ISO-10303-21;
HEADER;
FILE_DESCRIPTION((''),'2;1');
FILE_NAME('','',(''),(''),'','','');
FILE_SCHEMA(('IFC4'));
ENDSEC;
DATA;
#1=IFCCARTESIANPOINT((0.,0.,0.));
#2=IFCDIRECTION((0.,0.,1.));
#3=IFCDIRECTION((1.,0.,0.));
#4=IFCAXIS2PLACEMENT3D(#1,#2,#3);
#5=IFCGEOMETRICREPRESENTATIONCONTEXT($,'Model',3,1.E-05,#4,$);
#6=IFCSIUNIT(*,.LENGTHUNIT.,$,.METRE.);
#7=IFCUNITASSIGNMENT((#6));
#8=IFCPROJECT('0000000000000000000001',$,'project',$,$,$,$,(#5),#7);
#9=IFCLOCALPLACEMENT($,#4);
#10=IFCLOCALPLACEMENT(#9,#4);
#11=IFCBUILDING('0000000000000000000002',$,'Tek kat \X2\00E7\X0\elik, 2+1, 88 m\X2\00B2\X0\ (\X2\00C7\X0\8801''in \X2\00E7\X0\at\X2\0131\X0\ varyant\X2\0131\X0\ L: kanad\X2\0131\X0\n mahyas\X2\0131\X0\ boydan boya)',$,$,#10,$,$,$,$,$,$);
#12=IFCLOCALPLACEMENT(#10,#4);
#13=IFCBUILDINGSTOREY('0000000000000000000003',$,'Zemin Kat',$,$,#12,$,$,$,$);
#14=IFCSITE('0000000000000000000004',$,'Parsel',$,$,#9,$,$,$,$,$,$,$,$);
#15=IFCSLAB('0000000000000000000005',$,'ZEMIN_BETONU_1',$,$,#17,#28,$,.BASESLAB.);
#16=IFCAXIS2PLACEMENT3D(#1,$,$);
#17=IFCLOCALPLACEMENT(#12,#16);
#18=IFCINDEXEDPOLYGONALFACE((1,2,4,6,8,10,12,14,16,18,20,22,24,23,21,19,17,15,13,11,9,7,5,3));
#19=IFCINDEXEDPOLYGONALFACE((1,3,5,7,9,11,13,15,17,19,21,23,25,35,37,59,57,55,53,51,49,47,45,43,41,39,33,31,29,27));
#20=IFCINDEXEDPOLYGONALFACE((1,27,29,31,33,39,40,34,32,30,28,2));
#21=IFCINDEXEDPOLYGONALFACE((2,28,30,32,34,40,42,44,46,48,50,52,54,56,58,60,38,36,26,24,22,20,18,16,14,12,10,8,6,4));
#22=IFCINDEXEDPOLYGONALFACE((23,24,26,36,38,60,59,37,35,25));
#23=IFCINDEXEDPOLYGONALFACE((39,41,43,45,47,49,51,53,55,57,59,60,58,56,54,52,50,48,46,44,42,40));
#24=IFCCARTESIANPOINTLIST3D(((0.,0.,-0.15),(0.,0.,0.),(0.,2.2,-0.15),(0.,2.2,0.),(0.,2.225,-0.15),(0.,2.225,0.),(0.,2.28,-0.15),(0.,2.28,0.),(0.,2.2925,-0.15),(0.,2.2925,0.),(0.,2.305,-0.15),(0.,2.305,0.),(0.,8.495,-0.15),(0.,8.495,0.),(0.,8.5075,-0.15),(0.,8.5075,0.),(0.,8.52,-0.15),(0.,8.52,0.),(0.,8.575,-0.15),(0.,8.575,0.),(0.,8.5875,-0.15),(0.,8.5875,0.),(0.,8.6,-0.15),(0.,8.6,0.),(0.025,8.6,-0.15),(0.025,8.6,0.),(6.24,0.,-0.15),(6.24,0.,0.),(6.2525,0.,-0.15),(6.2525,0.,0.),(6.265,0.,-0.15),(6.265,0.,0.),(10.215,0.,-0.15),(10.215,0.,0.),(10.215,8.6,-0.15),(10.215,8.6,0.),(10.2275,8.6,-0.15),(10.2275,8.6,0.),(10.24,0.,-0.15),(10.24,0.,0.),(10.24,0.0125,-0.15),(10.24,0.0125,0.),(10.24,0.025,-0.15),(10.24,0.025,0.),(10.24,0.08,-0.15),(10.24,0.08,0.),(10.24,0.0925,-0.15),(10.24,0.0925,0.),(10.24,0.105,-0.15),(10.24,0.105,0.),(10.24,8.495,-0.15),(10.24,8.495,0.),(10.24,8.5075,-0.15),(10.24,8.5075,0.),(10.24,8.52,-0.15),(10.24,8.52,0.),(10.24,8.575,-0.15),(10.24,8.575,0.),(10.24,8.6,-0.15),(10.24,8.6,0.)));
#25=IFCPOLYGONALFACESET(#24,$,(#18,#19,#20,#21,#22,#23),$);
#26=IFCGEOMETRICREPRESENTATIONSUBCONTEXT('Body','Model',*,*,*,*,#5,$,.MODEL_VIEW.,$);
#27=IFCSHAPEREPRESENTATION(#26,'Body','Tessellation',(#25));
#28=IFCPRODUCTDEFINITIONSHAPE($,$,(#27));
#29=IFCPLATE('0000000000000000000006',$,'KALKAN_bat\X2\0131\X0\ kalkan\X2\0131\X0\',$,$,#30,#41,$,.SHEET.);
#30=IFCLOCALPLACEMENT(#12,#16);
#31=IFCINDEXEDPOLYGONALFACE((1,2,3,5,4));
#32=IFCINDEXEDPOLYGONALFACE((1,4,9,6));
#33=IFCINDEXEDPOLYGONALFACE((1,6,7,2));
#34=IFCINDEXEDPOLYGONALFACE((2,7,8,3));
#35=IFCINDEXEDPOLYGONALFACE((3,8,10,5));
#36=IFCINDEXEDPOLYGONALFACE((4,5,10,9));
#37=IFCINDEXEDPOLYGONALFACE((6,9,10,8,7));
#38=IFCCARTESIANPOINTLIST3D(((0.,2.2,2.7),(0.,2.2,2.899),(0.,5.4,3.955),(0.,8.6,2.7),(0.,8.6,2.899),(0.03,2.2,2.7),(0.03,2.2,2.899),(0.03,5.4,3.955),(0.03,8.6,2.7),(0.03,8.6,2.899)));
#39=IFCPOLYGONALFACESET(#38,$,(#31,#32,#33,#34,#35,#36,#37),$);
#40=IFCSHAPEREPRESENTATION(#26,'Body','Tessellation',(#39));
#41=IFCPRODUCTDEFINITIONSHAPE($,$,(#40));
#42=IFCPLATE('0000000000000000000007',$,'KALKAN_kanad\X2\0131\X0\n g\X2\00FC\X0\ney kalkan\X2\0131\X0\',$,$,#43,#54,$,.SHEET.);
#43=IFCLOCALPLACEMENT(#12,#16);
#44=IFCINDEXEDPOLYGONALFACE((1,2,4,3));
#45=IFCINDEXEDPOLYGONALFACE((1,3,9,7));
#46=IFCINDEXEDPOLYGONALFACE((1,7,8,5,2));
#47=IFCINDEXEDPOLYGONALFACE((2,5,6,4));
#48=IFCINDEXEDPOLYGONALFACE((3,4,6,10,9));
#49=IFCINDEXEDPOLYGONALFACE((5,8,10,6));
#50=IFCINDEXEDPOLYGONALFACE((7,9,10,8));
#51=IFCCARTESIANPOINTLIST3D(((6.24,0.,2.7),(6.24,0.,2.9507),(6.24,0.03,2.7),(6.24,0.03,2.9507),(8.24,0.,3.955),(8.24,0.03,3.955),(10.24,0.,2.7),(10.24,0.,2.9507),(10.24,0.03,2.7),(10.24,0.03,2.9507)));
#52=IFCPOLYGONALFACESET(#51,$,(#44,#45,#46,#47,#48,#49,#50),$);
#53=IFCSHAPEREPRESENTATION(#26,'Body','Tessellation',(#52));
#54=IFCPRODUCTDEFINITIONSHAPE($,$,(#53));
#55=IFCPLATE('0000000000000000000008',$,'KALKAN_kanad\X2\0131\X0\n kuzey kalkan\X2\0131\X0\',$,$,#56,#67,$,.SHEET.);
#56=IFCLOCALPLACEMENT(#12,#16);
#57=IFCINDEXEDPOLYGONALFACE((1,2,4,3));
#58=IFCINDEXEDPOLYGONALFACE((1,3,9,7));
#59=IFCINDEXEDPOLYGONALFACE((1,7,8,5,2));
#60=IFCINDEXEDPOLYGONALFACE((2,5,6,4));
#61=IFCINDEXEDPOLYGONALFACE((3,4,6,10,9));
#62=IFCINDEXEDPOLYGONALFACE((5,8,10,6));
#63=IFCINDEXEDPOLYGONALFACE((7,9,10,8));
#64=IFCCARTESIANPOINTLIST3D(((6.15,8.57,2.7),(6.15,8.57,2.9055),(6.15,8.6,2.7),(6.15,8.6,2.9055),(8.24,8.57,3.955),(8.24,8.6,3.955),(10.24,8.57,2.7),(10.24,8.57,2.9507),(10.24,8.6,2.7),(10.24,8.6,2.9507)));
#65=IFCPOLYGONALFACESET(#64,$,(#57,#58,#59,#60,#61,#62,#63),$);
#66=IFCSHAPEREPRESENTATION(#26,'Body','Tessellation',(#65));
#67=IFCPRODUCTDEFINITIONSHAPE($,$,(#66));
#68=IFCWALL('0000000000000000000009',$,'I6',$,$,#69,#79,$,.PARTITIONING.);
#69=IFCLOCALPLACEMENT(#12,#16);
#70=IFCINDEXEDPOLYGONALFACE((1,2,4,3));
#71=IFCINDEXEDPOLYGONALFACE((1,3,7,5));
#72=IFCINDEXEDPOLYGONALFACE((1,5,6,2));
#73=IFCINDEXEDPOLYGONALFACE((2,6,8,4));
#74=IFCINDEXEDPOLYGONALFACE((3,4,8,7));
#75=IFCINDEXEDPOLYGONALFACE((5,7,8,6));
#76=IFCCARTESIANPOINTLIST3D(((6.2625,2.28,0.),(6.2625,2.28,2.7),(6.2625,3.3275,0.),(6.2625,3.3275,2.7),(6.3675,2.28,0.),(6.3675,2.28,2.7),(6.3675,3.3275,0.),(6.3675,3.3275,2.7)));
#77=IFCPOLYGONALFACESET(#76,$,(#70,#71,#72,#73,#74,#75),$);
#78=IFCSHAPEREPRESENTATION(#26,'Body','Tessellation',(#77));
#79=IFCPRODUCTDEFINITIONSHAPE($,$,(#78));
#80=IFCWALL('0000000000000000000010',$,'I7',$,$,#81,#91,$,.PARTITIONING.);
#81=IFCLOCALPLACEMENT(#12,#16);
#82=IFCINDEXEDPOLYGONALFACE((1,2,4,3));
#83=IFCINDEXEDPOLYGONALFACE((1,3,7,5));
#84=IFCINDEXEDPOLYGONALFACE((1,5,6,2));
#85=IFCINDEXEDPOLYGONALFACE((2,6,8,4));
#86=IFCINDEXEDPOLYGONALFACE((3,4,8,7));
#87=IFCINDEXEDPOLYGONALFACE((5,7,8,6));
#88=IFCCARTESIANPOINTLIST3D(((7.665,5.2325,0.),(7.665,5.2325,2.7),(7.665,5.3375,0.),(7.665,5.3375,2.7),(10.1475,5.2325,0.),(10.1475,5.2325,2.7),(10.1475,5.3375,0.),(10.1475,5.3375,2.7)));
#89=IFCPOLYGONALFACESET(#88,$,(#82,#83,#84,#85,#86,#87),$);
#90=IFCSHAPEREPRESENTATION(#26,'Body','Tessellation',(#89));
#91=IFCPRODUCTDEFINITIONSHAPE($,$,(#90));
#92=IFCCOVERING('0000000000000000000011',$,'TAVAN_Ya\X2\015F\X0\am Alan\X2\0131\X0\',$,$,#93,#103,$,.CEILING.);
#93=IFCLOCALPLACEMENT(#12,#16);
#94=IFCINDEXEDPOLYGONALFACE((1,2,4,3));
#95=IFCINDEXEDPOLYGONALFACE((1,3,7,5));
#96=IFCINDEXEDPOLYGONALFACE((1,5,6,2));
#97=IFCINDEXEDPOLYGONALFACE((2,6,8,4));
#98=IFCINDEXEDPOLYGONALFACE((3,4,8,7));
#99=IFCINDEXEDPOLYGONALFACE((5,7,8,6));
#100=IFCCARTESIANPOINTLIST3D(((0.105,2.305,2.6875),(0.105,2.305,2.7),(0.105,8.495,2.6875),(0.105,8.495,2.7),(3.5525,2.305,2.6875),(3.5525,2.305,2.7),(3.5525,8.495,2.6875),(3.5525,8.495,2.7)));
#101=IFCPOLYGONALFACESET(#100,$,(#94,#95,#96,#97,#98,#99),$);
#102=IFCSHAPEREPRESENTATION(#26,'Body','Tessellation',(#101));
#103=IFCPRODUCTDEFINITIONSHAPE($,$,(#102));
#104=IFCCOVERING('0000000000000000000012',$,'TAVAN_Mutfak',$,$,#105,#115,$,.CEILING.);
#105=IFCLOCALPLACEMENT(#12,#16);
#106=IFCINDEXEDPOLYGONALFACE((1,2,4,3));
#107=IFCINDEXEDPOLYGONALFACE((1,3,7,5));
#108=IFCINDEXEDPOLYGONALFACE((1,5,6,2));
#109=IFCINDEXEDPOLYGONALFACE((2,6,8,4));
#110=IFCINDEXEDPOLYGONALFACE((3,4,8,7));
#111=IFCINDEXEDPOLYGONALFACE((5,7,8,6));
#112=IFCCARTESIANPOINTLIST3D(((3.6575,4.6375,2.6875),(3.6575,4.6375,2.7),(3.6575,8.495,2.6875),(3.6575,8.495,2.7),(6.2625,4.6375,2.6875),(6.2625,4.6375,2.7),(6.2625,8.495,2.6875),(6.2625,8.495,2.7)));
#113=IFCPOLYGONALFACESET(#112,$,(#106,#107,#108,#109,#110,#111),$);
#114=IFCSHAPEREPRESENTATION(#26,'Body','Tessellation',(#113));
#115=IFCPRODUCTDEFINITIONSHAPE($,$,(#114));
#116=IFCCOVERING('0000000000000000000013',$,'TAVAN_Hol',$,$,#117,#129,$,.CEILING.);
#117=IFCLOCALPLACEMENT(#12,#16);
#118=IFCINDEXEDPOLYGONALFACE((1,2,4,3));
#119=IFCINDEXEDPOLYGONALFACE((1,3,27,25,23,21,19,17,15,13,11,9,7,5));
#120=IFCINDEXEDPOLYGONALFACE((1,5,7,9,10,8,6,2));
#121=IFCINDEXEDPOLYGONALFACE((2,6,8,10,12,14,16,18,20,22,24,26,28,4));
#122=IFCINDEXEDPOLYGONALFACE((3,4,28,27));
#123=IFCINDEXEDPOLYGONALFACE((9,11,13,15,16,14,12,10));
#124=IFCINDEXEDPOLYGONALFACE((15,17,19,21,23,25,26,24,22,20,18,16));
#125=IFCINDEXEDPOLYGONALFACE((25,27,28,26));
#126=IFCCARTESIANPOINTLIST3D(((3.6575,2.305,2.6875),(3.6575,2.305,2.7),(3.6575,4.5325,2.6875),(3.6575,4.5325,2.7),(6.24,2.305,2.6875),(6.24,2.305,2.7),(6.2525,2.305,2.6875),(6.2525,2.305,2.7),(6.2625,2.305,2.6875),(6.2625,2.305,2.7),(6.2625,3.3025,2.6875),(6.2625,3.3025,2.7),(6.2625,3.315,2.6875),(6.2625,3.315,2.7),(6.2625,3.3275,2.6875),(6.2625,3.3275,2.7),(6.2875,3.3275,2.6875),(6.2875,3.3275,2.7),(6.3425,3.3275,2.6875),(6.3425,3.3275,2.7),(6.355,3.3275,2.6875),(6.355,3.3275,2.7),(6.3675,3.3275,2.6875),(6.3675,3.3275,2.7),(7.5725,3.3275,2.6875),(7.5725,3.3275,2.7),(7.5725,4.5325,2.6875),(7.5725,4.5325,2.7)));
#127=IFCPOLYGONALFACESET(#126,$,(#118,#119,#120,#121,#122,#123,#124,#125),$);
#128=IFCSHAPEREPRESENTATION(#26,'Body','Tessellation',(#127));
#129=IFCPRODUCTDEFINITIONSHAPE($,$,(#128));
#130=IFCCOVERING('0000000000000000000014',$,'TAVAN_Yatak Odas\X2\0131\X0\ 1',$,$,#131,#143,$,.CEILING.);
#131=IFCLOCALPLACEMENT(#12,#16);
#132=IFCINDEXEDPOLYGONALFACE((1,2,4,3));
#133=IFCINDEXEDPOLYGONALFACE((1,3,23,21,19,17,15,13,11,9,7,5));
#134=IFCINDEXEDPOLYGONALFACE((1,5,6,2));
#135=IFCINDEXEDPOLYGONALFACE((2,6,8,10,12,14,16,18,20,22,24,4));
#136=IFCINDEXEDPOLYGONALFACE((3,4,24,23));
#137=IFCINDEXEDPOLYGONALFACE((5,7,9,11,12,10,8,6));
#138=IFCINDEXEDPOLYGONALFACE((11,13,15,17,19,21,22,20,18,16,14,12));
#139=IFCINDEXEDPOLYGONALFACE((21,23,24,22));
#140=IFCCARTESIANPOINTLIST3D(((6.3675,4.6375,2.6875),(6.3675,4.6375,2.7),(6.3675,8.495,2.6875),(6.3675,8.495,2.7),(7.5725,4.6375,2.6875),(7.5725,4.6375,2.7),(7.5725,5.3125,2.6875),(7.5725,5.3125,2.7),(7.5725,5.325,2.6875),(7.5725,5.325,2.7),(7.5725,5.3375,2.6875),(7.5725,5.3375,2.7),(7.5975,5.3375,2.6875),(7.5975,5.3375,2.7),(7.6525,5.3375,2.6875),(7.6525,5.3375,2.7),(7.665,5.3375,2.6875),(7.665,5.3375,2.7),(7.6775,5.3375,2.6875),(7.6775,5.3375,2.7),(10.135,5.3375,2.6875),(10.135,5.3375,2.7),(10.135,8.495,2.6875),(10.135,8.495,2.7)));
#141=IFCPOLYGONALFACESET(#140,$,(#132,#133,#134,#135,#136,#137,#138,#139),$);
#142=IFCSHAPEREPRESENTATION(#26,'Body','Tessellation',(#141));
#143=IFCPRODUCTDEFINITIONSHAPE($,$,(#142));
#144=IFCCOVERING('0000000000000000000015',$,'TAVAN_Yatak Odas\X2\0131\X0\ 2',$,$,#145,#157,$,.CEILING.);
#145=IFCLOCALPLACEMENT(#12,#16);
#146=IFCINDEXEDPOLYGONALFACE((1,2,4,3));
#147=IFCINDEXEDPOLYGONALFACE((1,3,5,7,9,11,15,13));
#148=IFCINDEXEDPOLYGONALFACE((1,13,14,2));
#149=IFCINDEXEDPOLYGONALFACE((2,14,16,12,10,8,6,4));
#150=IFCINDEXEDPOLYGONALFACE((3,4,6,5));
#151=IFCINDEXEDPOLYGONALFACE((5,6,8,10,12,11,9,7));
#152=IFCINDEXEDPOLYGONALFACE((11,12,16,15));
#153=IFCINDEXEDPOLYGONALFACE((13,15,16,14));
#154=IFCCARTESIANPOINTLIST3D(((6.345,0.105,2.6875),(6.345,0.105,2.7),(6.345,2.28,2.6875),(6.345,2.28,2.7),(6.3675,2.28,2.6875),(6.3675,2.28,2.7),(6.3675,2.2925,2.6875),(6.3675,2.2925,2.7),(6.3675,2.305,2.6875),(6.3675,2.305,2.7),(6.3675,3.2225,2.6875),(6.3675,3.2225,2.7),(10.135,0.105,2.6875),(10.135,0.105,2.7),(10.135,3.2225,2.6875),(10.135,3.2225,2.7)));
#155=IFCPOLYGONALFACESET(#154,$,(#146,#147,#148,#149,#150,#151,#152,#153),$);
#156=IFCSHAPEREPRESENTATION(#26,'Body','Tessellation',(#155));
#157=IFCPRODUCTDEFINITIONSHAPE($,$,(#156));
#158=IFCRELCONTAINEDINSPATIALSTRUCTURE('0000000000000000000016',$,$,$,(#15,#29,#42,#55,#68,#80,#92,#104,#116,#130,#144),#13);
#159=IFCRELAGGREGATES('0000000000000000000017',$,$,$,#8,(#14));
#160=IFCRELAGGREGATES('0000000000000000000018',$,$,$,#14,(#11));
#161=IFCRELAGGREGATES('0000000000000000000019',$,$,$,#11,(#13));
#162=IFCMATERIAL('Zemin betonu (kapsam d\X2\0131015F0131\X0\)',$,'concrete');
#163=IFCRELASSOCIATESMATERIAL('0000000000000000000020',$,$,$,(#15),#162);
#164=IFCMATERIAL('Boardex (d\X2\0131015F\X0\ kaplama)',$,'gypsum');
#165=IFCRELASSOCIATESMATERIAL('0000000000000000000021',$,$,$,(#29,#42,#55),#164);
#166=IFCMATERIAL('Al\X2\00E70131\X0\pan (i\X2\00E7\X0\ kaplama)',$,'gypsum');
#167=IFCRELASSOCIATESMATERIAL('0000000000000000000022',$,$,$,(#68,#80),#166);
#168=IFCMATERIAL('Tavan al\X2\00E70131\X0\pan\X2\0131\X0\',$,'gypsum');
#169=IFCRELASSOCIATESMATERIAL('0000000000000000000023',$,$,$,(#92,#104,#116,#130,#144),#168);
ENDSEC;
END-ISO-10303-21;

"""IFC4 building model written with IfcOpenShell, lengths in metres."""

from ifc_helpers import new_model, si_unit, frame, origin_with_axes, place, context, subcontext, project, spatial, line, indexed_curve, outline, extrude, material, element, save


model = new_model("IFC4")

# Units and contexts
model_context = context("Model", 3, precision=1e-05, world=origin_with_axes())
body_context = subcontext(model_context, "Body", "Model", "MODEL_VIEW")
ifc_project = project(units=[si_unit("LENGTHUNIT", "METRE")], contexts=[model_context])

# Site, building, storey
site_placement = place(None, origin_with_axes())
site = spatial("IfcSite", under=ifc_project, at=site_placement, Name="Parsel")
building_placement = place(site_placement, origin_with_axes())
building = spatial("IfcBuilding", under=site, at=building_placement, Name="Tek kat çelik, 2+1, 88 m² (Ç8801'in çatı varyantı L: kanadın mahyası boydan boya)")
storey_placement = place(building_placement, origin_with_axes())
storey = spatial("IfcBuildingStorey", under=building, at=storey_placement, Name="Zemin Kat")

# Slab
ifc_material_1 = material(Name="Zemin betonu (kapsam dışı)", Category="concrete")
slab_placement = place(storey_placement, origin_with_axes())
element("IfcSlab", 1, at=slab_placement, inside=storey, material=ifc_material_1, Name="ZEMIN_BETONU_1", PredefinedType="BASESLAB", context=body_context, shape_type="SweptSolid", body=[
    extrude(outline(indexed_curve([(6.24, 0.0), (6.2525, 0.0), (6.265, 0.0), (10.215, 0.0), (10.24, 0.0), (10.24, 0.0125), (10.24, 0.025), (10.24, 0.08), (10.24, 0.0925), (10.24, 0.105), (10.24, 8.495), (10.24, 8.5075), (10.24, 8.52), (10.24, 8.575), (10.24, 8.6), (10.2275, 8.6), (10.215, 8.6), (0.025, 8.6), (0.0, 8.6), (0.0, 8.5875), (0.0, 8.575), (0.0, 8.52), (0.0, 8.5075), (0.0, 8.495), (0.0, 2.305), (0.0, 2.2925), (0.0, 2.28), (0.0, 2.225), (0.0, 2.2), (0.0, 0.0)], segments=[line(1, 2, 3, 4, 5, 6, 7, 8, 9, 10, 11, 12, 13, 14, 15, 16, 17, 18, 19, 20, 21, 22, 23, 24, 25, 26, 27, 28, 29, 30, 1)])), frame((0.0, 0.0, -0.15), z_axis=(0.0, 0.0, 1.0), x_axis=(1.0, 0.0, 0.0)), (0.0, 0.0, 1.0), 0.15),
])

# Plates
ifc_material_2 = material(Name="Boardex (dış kaplama)", Category="gypsum")
plate_1_placement = place(storey_placement, origin_with_axes())
element("IfcPlate", 2, at=plate_1_placement, inside=storey, material=ifc_material_2, Name="KALKAN_batı kalkanı", PredefinedType="SHEET", context=body_context, shape_type="SweptSolid", body=[
    extrude(outline(indexed_curve([(2.2, 2.899), (5.4, 3.955), (8.6, 2.899), (8.6, 2.7), (2.2, 2.7)], segments=[line(1, 2, 3, 4, 5, 1)])), frame((0.0, 0.0, 0.0), z_axis=(1.0, 0.0, 0.0), x_axis=(0.0, 1.0, 0.0)), (0.0, 0.0, 1.0), 0.03),
])
plate_2_placement = place(storey_placement, origin_with_axes())
element("IfcPlate", 3, at=plate_2_placement, inside=storey, material=ifc_material_2, Name="KALKAN_kanadın güney kalkanı", PredefinedType="SHEET", context=body_context, shape_type="SweptSolid", body=[
    extrude(outline(indexed_curve([(6.24, 2.9507), (8.24, 3.955), (10.24, 2.9507), (10.24, 2.7), (6.24, 2.7)], segments=[line(1, 2, 3, 4, 5, 1)])), frame((0.0, 0.03, 0.0), z_axis=(0.0, -1.0, 0.0), x_axis=(1.0, 0.0, 0.0)), (0.0, 0.0, 1.0), 0.03),
])
plate_3_placement = place(storey_placement, origin_with_axes())
element("IfcPlate", 4, at=plate_3_placement, inside=storey, material=ifc_material_2, Name="KALKAN_kanadın kuzey kalkanı", PredefinedType="SHEET", context=body_context, shape_type="SweptSolid", body=[
    extrude(outline(indexed_curve([(6.15, 2.9055), (8.24, 3.955), (10.24, 2.9507), (10.24, 2.7), (6.15, 2.7)], segments=[line(1, 2, 3, 4, 5, 1)])), frame((0.0, 8.6, 0.0), z_axis=(0.0, -1.0, 0.0), x_axis=(1.0, 0.0, 0.0)), (0.0, 0.0, 1.0), 0.03),
])

# Walls
ifc_material_3 = material(Name="Alçıpan (iç kaplama)", Category="gypsum")
wall_1_placement = place(storey_placement, origin_with_axes())
element("IfcWall", 5, at=wall_1_placement, inside=storey, material=ifc_material_3, Name="I6", PredefinedType="PARTITIONING", context=body_context, shape_type="SweptSolid", body=[
    extrude(outline(indexed_curve([(0.0, 0.0), (0.105, 0.0), (0.105, 1.0475), (0.0, 1.0475)], segments=[line(1, 2, 3, 4, 1)])), frame((6.2625, 2.28, 0.0), z_axis=(0.0, 0.0, 1.0), x_axis=(1.0, 0.0, 0.0)), (0.0, 0.0, 1.0), 2.7),
])
wall_2_placement = place(storey_placement, origin_with_axes())
element("IfcWall", 6, at=wall_2_placement, inside=storey, material=ifc_material_3, Name="I7", PredefinedType="PARTITIONING", context=body_context, shape_type="SweptSolid", body=[
    extrude(outline(indexed_curve([(0.0, 0.0), (2.4825, 0.0), (2.4825, 0.105), (0.0, 0.105)], segments=[line(1, 2, 3, 4, 1)])), frame((7.665, 5.2325, 0.0), z_axis=(0.0, 0.0, 1.0), x_axis=(1.0, 0.0, 0.0)), (0.0, 0.0, 1.0), 2.7),
])

# Coverings
ifc_material_4 = material(Name="Tavan alçıpanı", Category="gypsum")
covering_1_placement = place(storey_placement, origin_with_axes())
element("IfcCovering", 7, at=covering_1_placement, inside=storey, material=ifc_material_4, Name="TAVAN_Yaşam Alanı", PredefinedType="CEILING", context=body_context, shape_type="SweptSolid", body=[
    extrude(outline(indexed_curve([(0.105, 8.495), (3.5525, 8.495), (3.5525, 2.305), (0.105, 2.305)], segments=[line(1, 2, 3, 4, 1)])), frame((0.0, 0.0, 2.6875), z_axis=(0.0, 0.0, 1.0), x_axis=(1.0, 0.0, 0.0)), (0.0, 0.0, 1.0), 0.0125),
])
covering_2_placement = place(storey_placement, origin_with_axes())
element("IfcCovering", 8, at=covering_2_placement, inside=storey, material=ifc_material_4, Name="TAVAN_Mutfak", PredefinedType="CEILING", context=body_context, shape_type="SweptSolid", body=[
    extrude(outline(indexed_curve([(3.6575, 8.495), (6.2625, 8.495), (6.2625, 4.6375), (3.6575, 4.6375)], segments=[line(1, 2, 3, 4, 1)])), frame((0.0, 0.0, 2.6875), z_axis=(0.0, 0.0, 1.0), x_axis=(1.0, 0.0, 0.0)), (0.0, 0.0, 1.0), 0.0125),
])
covering_3_placement = place(storey_placement, origin_with_axes())
element("IfcCovering", 9, at=covering_3_placement, inside=storey, material=ifc_material_4, Name="TAVAN_Hol", PredefinedType="CEILING", context=body_context, shape_type="SweptSolid", body=[
    extrude(outline(indexed_curve([(6.24, 2.305), (3.6575, 2.305), (3.6575, 4.5325), (7.5725, 4.5325), (7.5725, 3.3275), (6.3675, 3.3275), (6.355, 3.3275), (6.3425, 3.3275), (6.2875, 3.3275), (6.2625, 3.3275), (6.2625, 3.315), (6.2625, 3.3025), (6.2625, 2.305), (6.2525, 2.305)], segments=[line(1, 2, 3, 4, 5, 6, 7, 8, 9, 10, 11, 12, 13, 14, 1)])), frame((0.0, 0.0, 2.6875), z_axis=(0.0, 0.0, 1.0), x_axis=(1.0, 0.0, 0.0)), (0.0, 0.0, 1.0), 0.0125),
])
covering_4_placement = place(storey_placement, origin_with_axes())
element("IfcCovering", 10, at=covering_4_placement, inside=storey, material=ifc_material_4, Name="TAVAN_Yatak Odası 1", PredefinedType="CEILING", context=body_context, shape_type="SweptSolid", body=[
    extrude(outline(indexed_curve([(6.3675, 8.495), (10.135, 8.495), (10.135, 5.3375), (7.6775, 5.3375), (7.665, 5.3375), (7.6525, 5.3375), (7.5975, 5.3375), (7.5725, 5.3375), (7.5725, 5.325), (7.5725, 5.3125), (7.5725, 4.6375), (6.3675, 4.6375)], segments=[line(1, 2, 3, 4, 5, 6, 7, 8, 9, 10, 11, 12, 1)])), frame((0.0, 0.0, 2.6875), z_axis=(0.0, 0.0, 1.0), x_axis=(1.0, 0.0, 0.0)), (0.0, 0.0, 1.0), 0.0125),
])
covering_5_placement = place(storey_placement, origin_with_axes())
element("IfcCovering", 11, at=covering_5_placement, inside=storey, material=ifc_material_4, Name="TAVAN_Yatak Odası 2", PredefinedType="CEILING", context=body_context, shape_type="SweptSolid", body=[
    extrude(outline(indexed_curve([(6.3675, 3.2225), (10.135, 3.2225), (10.135, 0.105), (6.345, 0.105), (6.345, 2.28), (6.3675, 2.28), (6.3675, 2.2925), (6.3675, 2.305)], segments=[line(1, 2, 3, 4, 5, 6, 7, 8, 1)])), frame((0.0, 0.0, 2.6875), z_axis=(0.0, 0.0, 1.0), x_axis=(1.0, 0.0, 0.0)), (0.0, 0.0, 1.0), 0.0125),
])

save(model, "model.ifc")
